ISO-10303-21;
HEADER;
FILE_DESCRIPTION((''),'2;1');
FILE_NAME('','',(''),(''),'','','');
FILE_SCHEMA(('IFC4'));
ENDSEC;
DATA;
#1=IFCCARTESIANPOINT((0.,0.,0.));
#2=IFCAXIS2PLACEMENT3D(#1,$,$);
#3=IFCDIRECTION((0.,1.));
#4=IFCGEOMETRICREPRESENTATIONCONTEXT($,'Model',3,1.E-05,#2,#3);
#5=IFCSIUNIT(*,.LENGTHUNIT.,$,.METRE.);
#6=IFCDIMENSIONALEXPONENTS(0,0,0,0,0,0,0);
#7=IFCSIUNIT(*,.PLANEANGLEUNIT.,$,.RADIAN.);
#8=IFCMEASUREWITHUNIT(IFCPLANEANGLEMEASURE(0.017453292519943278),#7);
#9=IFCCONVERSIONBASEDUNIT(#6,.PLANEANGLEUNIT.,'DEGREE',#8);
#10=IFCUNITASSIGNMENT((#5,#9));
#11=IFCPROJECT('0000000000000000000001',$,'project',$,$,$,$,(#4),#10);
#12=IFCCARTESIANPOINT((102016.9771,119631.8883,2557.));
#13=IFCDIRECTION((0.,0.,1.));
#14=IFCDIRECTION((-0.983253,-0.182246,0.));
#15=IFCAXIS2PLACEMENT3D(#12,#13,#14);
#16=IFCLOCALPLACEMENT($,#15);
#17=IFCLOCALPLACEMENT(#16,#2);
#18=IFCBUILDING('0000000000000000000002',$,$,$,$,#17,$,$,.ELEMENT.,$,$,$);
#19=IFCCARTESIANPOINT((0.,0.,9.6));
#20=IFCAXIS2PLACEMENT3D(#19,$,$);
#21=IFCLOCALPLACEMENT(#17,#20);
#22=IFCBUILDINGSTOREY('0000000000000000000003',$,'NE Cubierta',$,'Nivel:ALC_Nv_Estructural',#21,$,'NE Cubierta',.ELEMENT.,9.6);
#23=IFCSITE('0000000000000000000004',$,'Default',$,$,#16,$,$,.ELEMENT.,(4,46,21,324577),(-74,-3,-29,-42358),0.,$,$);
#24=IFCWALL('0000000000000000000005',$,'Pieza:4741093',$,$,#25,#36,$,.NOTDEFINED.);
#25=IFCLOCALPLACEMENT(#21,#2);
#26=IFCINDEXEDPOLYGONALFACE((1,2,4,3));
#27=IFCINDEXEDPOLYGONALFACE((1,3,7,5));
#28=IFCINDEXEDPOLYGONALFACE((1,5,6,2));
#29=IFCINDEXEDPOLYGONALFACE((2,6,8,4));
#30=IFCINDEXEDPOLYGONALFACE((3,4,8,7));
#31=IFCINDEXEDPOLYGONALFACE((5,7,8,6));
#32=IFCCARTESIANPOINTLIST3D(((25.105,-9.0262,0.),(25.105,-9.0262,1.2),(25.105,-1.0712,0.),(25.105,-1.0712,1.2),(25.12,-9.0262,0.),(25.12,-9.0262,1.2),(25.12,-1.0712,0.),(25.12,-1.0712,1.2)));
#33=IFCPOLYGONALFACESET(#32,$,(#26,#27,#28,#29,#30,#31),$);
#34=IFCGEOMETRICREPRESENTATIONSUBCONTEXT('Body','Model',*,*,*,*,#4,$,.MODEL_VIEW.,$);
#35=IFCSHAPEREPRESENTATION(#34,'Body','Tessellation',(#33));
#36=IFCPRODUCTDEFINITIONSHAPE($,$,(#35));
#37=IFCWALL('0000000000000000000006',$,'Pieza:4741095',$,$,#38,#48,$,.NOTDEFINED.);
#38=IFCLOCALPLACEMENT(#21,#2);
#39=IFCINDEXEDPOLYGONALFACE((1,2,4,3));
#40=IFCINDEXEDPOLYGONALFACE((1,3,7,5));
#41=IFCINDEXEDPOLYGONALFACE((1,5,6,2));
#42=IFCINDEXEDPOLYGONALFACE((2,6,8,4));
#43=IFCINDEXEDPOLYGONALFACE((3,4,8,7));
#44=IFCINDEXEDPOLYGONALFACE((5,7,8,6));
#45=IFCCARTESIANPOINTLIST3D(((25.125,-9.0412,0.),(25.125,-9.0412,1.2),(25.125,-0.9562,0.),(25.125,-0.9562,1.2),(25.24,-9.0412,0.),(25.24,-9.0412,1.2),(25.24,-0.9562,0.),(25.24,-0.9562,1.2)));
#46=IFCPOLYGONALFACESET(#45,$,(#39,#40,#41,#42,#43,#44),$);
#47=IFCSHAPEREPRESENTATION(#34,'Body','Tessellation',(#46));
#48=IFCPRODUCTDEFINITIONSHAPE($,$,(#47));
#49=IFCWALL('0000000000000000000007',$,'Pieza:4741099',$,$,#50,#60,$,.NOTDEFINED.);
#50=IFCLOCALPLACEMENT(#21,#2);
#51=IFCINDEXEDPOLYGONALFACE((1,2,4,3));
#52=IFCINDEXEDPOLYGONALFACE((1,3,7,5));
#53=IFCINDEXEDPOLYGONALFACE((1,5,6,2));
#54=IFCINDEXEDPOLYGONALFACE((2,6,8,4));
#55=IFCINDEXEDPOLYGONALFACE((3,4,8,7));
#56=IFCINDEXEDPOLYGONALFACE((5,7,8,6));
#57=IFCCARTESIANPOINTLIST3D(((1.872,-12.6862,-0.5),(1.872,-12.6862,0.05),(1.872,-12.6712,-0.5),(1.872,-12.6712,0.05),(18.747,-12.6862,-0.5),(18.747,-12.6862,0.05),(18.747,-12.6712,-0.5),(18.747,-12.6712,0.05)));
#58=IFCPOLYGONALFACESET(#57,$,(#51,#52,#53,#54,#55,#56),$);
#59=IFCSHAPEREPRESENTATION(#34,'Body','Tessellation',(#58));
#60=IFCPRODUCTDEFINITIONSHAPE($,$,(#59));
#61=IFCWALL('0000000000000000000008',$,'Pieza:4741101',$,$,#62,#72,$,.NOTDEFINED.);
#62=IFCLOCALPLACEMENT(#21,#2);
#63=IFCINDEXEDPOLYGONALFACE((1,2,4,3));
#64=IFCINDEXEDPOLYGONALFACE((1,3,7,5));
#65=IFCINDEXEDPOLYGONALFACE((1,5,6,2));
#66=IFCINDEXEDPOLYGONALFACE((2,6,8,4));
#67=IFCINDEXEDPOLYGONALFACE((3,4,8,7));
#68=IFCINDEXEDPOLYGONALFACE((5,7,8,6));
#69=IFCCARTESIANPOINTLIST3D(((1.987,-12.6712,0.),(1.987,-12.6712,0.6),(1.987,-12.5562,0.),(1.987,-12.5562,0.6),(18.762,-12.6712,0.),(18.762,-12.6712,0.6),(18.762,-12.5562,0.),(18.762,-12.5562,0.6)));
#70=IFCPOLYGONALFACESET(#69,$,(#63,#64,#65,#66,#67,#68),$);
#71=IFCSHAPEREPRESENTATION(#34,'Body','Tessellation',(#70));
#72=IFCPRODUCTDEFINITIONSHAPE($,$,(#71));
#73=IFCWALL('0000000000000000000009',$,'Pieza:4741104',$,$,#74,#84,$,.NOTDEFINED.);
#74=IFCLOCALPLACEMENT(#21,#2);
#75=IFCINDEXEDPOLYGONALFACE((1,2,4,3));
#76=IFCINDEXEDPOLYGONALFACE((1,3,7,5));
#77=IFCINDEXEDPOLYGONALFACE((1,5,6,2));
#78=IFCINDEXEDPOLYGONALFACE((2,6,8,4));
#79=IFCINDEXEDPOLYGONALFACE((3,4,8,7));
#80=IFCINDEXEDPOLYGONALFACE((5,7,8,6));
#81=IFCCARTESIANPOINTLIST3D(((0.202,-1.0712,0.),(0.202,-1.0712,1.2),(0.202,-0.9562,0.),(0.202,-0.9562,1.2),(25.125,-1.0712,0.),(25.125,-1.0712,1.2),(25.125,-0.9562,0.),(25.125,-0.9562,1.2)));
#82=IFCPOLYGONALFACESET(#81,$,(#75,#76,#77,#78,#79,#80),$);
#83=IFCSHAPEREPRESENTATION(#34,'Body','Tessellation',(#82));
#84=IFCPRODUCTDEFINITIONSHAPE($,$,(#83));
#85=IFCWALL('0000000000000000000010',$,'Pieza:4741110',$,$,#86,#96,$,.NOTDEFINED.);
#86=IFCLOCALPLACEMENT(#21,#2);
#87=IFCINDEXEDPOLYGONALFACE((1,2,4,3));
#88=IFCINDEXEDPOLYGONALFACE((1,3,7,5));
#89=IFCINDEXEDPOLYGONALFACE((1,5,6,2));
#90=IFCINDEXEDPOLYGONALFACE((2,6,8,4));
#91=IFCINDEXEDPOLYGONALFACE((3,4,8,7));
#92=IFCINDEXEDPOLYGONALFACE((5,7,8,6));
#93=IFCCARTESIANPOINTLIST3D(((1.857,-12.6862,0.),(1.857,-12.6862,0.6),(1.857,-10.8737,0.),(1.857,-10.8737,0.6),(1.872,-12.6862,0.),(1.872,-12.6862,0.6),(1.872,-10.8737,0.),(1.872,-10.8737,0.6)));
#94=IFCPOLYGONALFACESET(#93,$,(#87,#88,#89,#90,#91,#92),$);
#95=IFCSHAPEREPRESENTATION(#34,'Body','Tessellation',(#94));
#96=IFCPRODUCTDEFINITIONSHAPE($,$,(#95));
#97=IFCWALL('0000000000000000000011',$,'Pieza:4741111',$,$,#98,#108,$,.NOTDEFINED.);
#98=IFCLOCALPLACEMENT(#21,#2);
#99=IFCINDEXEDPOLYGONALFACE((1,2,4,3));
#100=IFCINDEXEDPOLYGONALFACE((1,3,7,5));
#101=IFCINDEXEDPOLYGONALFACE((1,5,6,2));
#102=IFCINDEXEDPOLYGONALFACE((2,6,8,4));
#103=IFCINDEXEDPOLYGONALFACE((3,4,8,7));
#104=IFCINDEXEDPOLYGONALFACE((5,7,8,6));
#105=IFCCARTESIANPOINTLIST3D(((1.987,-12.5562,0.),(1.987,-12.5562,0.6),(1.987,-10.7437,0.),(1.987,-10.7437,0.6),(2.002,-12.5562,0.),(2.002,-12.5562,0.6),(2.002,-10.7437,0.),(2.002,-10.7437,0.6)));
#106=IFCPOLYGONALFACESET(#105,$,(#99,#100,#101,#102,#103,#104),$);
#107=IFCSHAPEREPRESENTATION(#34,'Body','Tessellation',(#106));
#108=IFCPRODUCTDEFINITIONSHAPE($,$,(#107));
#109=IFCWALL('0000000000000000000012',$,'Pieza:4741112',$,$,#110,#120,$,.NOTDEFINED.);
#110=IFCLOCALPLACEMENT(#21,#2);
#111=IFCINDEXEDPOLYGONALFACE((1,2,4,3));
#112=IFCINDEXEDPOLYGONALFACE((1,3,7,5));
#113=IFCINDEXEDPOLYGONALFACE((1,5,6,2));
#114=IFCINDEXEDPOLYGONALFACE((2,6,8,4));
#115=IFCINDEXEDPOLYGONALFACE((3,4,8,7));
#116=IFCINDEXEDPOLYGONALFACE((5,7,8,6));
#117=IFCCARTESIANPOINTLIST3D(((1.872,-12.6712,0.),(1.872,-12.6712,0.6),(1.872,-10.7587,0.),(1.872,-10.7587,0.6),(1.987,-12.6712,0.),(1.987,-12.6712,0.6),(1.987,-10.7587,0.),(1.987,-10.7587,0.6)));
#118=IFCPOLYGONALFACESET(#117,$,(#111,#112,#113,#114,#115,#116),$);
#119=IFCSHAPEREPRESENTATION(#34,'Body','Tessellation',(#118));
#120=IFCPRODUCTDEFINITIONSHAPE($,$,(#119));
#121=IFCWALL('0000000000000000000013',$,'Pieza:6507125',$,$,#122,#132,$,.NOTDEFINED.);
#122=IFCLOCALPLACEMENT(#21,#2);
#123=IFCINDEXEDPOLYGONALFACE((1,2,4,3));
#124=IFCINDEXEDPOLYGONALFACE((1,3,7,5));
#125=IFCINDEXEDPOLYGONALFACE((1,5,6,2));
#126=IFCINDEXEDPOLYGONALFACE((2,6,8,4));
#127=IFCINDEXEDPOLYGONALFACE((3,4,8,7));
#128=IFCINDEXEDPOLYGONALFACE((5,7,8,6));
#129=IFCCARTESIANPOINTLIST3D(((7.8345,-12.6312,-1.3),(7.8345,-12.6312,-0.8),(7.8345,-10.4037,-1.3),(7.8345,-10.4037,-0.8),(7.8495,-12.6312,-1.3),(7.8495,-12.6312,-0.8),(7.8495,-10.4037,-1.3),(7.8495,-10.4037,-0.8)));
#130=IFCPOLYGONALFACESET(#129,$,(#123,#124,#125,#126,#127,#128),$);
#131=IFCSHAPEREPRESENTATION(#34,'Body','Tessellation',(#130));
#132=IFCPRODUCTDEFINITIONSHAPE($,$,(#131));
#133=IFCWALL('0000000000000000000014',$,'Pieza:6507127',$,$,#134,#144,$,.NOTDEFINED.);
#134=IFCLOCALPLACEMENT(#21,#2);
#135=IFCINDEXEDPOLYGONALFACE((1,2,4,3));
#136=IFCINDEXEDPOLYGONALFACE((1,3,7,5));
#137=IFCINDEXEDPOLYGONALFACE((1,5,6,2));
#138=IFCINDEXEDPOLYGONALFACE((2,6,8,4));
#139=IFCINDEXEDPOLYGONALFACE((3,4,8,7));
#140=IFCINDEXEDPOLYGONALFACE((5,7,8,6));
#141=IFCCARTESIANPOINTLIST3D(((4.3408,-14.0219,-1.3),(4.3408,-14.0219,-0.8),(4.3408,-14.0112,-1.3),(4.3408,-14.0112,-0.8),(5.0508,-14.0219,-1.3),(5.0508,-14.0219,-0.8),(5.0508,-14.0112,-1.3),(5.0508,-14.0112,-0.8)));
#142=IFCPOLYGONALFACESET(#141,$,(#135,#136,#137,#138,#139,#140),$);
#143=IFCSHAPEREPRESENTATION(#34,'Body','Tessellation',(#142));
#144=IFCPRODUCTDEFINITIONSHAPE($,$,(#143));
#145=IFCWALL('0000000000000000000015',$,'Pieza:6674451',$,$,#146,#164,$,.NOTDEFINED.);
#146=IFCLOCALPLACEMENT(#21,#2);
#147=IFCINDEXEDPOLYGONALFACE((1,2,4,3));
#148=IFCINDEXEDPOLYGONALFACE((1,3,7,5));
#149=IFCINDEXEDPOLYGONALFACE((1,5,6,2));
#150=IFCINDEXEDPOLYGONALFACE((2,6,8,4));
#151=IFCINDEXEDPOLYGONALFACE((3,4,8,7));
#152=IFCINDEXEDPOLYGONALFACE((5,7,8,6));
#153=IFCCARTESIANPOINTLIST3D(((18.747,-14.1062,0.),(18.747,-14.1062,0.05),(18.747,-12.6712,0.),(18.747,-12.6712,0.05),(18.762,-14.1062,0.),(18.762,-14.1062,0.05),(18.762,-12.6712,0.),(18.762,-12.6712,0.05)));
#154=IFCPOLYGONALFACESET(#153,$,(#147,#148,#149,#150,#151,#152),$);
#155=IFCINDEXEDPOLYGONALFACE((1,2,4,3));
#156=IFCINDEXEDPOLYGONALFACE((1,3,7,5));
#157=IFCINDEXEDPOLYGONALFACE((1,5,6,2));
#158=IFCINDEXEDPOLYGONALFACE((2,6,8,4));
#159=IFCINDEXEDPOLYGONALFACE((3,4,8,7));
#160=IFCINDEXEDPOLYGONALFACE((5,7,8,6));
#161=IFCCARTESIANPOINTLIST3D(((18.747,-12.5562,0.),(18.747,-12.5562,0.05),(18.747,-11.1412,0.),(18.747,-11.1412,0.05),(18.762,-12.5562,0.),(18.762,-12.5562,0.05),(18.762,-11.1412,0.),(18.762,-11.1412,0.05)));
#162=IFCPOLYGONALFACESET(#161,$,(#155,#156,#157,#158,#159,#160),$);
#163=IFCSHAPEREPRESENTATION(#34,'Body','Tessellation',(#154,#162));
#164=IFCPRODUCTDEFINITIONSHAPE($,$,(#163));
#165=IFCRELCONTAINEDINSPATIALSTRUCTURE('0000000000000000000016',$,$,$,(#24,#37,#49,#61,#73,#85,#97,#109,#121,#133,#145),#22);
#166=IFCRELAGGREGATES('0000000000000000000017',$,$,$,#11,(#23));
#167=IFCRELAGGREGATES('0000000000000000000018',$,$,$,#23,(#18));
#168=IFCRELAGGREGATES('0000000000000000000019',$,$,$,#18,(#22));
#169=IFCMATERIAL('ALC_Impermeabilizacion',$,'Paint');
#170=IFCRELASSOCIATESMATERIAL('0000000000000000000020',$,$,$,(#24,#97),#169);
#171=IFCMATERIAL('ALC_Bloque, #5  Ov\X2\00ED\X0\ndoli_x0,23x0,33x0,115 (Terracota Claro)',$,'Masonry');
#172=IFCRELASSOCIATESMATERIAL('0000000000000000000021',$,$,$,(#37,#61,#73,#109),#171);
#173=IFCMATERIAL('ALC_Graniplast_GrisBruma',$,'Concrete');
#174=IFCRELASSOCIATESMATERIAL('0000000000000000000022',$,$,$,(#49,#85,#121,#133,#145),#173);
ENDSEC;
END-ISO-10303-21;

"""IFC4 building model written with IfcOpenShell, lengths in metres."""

from ifc_helpers import new_model, entity, si_unit, converted_unit, direction, frame, frame_2d, origin, origin_2d_with_axis, place, context, subcontext, project, spatial, rectangle, extrude, material, element, save


model = new_model("IFC4")

# Units and contexts
model_context = context("Model", 3, precision=1e-05, world=origin(), true_north=direction((0.0, 1.0)))
body_context = subcontext(model_context, "Body", "Model", "MODEL_VIEW")
ifc_project = project(units=[si_unit("LENGTHUNIT", "METRE"), converted_unit("PLANEANGLEUNIT", "DEGREE", entity("IfcPlaneAngleMeasure", 0.017453292519943278), si_unit("PLANEANGLEUNIT", "RADIAN"), dimensions=[0, 0, 0, 0, 0, 0, 0])], contexts=[model_context])

# Site, building, storey
site_placement = place(None, frame((102016.9771, 119631.8883, 2557.0), z_axis=(0.0, 0.0, 1.0), x_axis=(-0.983253, -0.182246, 0.0)))
site = spatial("IfcSite", under=ifc_project, at=site_placement, Name="Default", CompositionType="ELEMENT", RefLatitude=(4, 46, 21, 324577), RefLongitude=(-74, -3, -29, -42358), RefElevation=0.0)
building_placement = place(site_placement, origin())
building = spatial("IfcBuilding", under=site, at=building_placement, CompositionType="ELEMENT")
storey_placement = place(building_placement, frame((0.0, 0.0, 9.6)))
storey = spatial("IfcBuildingStorey", under=building, at=storey_placement, Name="NE Cubierta", ObjectType="Nivel:ALC_Nv_Estructural", LongName="NE Cubierta", CompositionType="ELEMENT", Elevation=9.6)

# Walls
ifc_material_1 = material(Name="ALC_Graniplast_GrisBruma", Category="Concrete")
ifc_material_2 = material(Name="ALC_Impermeabilizacion", Category="Paint")
wall_1_placement = place(storey_placement, origin())
element("IfcWall", 1, at=wall_1_placement, inside=storey, material=ifc_material_2, Name="Pieza:4741093", PredefinedType="NOTDEFINED", context=body_context, shape_type="SweptSolid", body=[
    extrude(rectangle(XDim=7.955, YDim=0.015, at=frame_2d((0.0, 0.0), x_axis=(1.0, 0.0))), frame((25.1125, -5.0487, 0.0), z_axis=(0.0, 0.0, 1.0), x_axis=(0.0, -1.0, 0.0)), (0.0, 0.0, 1.0), 1.2),
])
ifc_material_3 = material(Name="ALC_Bloque, #5  Ovíndoli_x0,23x0,33x0,115 (Terracota Claro)", Category="Masonry")
wall_2_placement = place(storey_placement, origin())
element("IfcWall", 2, at=wall_2_placement, inside=storey, material=ifc_material_3, Name="Pieza:4741095", PredefinedType="NOTDEFINED", context=body_context, shape_type="SweptSolid", body=[
    extrude(rectangle(XDim=8.085, YDim=0.115, at=origin_2d_with_axis()), frame((25.1825, -4.9987, 0.0), z_axis=(0.0, 0.0, 1.0), x_axis=(0.0, -1.0, 0.0)), (0.0, 0.0, 1.0), 1.2),
])
wall_3_placement = place(storey_placement, frame((0.0, 0.0, -0.5)))
element("IfcWall", 3, at=wall_3_placement, inside=storey, material=ifc_material_1, Name="Pieza:4741099", PredefinedType="NOTDEFINED", context=body_context, shape_type="SweptSolid", body=[
    extrude(rectangle(XDim=0.015, YDim=16.875, at=frame_2d((0.0, 0.0), x_axis=(1.0, 0.0))), frame((10.3095, -12.6787, 0.0), z_axis=(0.0, 0.0, 1.0), x_axis=(0.0, -1.0, 0.0)), (0.0, 0.0, 1.0), 0.55),
])
wall_4_placement = place(storey_placement, origin())
element("IfcWall", 4, at=wall_4_placement, inside=storey, material=ifc_material_3, Name="Pieza:4741101", PredefinedType="NOTDEFINED", context=body_context, shape_type="SweptSolid", body=[
    extrude(rectangle(XDim=0.115, YDim=16.775, at=frame_2d((0.0, 0.0), x_axis=(1.0, 0.0))), frame((10.3745, -12.6137, 0.0), z_axis=(0.0, 0.0, 1.0), x_axis=(0.0, -1.0, 0.0)), (0.0, 0.0, 1.0), 0.6),
])
wall_5_placement = place(storey_placement, origin())
element("IfcWall", 5, at=wall_5_placement, inside=storey, material=ifc_material_3, Name="Pieza:4741104", PredefinedType="NOTDEFINED", context=body_context, shape_type="SweptSolid", body=[
    extrude(rectangle(XDim=0.115, YDim=24.923, at=frame_2d((0.0, 0.0), x_axis=(1.0, 0.0))), frame((12.6635, -1.0137, 0.0), z_axis=(0.0, 0.0, 1.0), x_axis=(0.0, -1.0, 0.0)), (0.0, 0.0, 1.0), 1.2),
])
wall_6_placement = place(storey_placement, origin())
element("IfcWall", 6, at=wall_6_placement, inside=storey, material=ifc_material_1, Name="Pieza:4741110", PredefinedType="NOTDEFINED", context=body_context, shape_type="SweptSolid", body=[
    extrude(rectangle(XDim=1.8125, YDim=0.015, at=frame_2d((0.0, 0.0), x_axis=(1.0, 0.0))), frame((1.8645, -11.7799, 0.0), z_axis=(0.0, 0.0, 1.0), x_axis=(0.0, -1.0, 0.0)), (0.0, 0.0, 1.0), 0.6),
])
wall_7_placement = place(storey_placement, origin())
element("IfcWall", 7, at=wall_7_placement, inside=storey, material=ifc_material_2, Name="Pieza:4741111", PredefinedType="NOTDEFINED", context=body_context, shape_type="SweptSolid", body=[
    extrude(rectangle(XDim=1.8125, YDim=0.015, at=frame_2d((0.0, 0.0), x_axis=(1.0, 0.0))), frame((1.9945, -11.6499, 0.0), z_axis=(0.0, 0.0, 1.0), x_axis=(0.0, -1.0, 0.0)), (0.0, 0.0, 1.0), 0.6),
])
wall_8_placement = place(storey_placement, origin())
element("IfcWall", 8, at=wall_8_placement, inside=storey, material=ifc_material_3, Name="Pieza:4741112", PredefinedType="NOTDEFINED", context=body_context, shape_type="SweptSolid", body=[
    extrude(rectangle(XDim=1.9125, YDim=0.115, at=frame_2d((0.0, 0.0), x_axis=(1.0, 0.0))), frame((1.9295, -11.7149, 0.0), z_axis=(0.0, 0.0, 1.0), x_axis=(0.0, -1.0, 0.0)), (0.0, 0.0, 1.0), 0.6),
])
wall_9_placement = place(storey_placement, frame((0.0, 0.0, -1.3)))
element("IfcWall", 9, at=wall_9_placement, inside=storey, material=ifc_material_1, Name="Pieza:6507125", PredefinedType="NOTDEFINED", context=body_context, shape_type="SweptSolid", body=[
    extrude(rectangle(XDim=2.2275, YDim=0.015, at=frame_2d((0.0, 0.0), x_axis=(1.0, 0.0))), frame((7.842, -11.5174, 0.0), z_axis=(0.0, 0.0, 1.0), x_axis=(0.0, -1.0, 0.0)), (0.0, 0.0, 1.0), 0.5),
])
wall_10_placement = place(storey_placement, frame((0.0, 0.0, -1.3)))
element("IfcWall", 10, at=wall_10_placement, inside=storey, material=ifc_material_1, Name="Pieza:6507127", PredefinedType="NOTDEFINED", context=body_context, shape_type="SweptSolid", body=[
    extrude(rectangle(XDim=0.0108, YDim=0.71, at=frame_2d((0.0, 0.0), x_axis=(1.0, 0.0))), frame((4.6958, -14.0166, 0.0), z_axis=(0.0, 0.0, 1.0), x_axis=(0.0, -1.0, 0.0)), (0.0, 0.0, 1.0), 0.5),
])
wall_11_placement = place(storey_placement, frame((0.0, 0.0, -9.6)))
element("IfcWall", 11, at=wall_11_placement, inside=storey, material=ifc_material_1, Name="Pieza:6674451", PredefinedType="NOTDEFINED", context=body_context, shape_type="SweptSolid", body=[
    extrude(rectangle(XDim=1.435, YDim=0.015, at=frame_2d((0.0, 0.0), x_axis=(1.0, 0.0))), frame((18.7545, -13.3887, 9.6), z_axis=(0.0, 0.0, 1.0), x_axis=(0.0, 1.0, 0.0)), (0.0, 0.0, 1.0), 0.05),
    extrude(rectangle(XDim=0.015, YDim=1.415, at=frame_2d((0.0, 0.0), x_axis=(1.0, 0.0))), frame((18.7545, -11.8487, 9.6), z_axis=(0.0, 0.0, 1.0), x_axis=(-1.0, 0.0, 0.0)), (0.0, 0.0, 1.0), 0.05),
])

save(model, "model.ifc")
